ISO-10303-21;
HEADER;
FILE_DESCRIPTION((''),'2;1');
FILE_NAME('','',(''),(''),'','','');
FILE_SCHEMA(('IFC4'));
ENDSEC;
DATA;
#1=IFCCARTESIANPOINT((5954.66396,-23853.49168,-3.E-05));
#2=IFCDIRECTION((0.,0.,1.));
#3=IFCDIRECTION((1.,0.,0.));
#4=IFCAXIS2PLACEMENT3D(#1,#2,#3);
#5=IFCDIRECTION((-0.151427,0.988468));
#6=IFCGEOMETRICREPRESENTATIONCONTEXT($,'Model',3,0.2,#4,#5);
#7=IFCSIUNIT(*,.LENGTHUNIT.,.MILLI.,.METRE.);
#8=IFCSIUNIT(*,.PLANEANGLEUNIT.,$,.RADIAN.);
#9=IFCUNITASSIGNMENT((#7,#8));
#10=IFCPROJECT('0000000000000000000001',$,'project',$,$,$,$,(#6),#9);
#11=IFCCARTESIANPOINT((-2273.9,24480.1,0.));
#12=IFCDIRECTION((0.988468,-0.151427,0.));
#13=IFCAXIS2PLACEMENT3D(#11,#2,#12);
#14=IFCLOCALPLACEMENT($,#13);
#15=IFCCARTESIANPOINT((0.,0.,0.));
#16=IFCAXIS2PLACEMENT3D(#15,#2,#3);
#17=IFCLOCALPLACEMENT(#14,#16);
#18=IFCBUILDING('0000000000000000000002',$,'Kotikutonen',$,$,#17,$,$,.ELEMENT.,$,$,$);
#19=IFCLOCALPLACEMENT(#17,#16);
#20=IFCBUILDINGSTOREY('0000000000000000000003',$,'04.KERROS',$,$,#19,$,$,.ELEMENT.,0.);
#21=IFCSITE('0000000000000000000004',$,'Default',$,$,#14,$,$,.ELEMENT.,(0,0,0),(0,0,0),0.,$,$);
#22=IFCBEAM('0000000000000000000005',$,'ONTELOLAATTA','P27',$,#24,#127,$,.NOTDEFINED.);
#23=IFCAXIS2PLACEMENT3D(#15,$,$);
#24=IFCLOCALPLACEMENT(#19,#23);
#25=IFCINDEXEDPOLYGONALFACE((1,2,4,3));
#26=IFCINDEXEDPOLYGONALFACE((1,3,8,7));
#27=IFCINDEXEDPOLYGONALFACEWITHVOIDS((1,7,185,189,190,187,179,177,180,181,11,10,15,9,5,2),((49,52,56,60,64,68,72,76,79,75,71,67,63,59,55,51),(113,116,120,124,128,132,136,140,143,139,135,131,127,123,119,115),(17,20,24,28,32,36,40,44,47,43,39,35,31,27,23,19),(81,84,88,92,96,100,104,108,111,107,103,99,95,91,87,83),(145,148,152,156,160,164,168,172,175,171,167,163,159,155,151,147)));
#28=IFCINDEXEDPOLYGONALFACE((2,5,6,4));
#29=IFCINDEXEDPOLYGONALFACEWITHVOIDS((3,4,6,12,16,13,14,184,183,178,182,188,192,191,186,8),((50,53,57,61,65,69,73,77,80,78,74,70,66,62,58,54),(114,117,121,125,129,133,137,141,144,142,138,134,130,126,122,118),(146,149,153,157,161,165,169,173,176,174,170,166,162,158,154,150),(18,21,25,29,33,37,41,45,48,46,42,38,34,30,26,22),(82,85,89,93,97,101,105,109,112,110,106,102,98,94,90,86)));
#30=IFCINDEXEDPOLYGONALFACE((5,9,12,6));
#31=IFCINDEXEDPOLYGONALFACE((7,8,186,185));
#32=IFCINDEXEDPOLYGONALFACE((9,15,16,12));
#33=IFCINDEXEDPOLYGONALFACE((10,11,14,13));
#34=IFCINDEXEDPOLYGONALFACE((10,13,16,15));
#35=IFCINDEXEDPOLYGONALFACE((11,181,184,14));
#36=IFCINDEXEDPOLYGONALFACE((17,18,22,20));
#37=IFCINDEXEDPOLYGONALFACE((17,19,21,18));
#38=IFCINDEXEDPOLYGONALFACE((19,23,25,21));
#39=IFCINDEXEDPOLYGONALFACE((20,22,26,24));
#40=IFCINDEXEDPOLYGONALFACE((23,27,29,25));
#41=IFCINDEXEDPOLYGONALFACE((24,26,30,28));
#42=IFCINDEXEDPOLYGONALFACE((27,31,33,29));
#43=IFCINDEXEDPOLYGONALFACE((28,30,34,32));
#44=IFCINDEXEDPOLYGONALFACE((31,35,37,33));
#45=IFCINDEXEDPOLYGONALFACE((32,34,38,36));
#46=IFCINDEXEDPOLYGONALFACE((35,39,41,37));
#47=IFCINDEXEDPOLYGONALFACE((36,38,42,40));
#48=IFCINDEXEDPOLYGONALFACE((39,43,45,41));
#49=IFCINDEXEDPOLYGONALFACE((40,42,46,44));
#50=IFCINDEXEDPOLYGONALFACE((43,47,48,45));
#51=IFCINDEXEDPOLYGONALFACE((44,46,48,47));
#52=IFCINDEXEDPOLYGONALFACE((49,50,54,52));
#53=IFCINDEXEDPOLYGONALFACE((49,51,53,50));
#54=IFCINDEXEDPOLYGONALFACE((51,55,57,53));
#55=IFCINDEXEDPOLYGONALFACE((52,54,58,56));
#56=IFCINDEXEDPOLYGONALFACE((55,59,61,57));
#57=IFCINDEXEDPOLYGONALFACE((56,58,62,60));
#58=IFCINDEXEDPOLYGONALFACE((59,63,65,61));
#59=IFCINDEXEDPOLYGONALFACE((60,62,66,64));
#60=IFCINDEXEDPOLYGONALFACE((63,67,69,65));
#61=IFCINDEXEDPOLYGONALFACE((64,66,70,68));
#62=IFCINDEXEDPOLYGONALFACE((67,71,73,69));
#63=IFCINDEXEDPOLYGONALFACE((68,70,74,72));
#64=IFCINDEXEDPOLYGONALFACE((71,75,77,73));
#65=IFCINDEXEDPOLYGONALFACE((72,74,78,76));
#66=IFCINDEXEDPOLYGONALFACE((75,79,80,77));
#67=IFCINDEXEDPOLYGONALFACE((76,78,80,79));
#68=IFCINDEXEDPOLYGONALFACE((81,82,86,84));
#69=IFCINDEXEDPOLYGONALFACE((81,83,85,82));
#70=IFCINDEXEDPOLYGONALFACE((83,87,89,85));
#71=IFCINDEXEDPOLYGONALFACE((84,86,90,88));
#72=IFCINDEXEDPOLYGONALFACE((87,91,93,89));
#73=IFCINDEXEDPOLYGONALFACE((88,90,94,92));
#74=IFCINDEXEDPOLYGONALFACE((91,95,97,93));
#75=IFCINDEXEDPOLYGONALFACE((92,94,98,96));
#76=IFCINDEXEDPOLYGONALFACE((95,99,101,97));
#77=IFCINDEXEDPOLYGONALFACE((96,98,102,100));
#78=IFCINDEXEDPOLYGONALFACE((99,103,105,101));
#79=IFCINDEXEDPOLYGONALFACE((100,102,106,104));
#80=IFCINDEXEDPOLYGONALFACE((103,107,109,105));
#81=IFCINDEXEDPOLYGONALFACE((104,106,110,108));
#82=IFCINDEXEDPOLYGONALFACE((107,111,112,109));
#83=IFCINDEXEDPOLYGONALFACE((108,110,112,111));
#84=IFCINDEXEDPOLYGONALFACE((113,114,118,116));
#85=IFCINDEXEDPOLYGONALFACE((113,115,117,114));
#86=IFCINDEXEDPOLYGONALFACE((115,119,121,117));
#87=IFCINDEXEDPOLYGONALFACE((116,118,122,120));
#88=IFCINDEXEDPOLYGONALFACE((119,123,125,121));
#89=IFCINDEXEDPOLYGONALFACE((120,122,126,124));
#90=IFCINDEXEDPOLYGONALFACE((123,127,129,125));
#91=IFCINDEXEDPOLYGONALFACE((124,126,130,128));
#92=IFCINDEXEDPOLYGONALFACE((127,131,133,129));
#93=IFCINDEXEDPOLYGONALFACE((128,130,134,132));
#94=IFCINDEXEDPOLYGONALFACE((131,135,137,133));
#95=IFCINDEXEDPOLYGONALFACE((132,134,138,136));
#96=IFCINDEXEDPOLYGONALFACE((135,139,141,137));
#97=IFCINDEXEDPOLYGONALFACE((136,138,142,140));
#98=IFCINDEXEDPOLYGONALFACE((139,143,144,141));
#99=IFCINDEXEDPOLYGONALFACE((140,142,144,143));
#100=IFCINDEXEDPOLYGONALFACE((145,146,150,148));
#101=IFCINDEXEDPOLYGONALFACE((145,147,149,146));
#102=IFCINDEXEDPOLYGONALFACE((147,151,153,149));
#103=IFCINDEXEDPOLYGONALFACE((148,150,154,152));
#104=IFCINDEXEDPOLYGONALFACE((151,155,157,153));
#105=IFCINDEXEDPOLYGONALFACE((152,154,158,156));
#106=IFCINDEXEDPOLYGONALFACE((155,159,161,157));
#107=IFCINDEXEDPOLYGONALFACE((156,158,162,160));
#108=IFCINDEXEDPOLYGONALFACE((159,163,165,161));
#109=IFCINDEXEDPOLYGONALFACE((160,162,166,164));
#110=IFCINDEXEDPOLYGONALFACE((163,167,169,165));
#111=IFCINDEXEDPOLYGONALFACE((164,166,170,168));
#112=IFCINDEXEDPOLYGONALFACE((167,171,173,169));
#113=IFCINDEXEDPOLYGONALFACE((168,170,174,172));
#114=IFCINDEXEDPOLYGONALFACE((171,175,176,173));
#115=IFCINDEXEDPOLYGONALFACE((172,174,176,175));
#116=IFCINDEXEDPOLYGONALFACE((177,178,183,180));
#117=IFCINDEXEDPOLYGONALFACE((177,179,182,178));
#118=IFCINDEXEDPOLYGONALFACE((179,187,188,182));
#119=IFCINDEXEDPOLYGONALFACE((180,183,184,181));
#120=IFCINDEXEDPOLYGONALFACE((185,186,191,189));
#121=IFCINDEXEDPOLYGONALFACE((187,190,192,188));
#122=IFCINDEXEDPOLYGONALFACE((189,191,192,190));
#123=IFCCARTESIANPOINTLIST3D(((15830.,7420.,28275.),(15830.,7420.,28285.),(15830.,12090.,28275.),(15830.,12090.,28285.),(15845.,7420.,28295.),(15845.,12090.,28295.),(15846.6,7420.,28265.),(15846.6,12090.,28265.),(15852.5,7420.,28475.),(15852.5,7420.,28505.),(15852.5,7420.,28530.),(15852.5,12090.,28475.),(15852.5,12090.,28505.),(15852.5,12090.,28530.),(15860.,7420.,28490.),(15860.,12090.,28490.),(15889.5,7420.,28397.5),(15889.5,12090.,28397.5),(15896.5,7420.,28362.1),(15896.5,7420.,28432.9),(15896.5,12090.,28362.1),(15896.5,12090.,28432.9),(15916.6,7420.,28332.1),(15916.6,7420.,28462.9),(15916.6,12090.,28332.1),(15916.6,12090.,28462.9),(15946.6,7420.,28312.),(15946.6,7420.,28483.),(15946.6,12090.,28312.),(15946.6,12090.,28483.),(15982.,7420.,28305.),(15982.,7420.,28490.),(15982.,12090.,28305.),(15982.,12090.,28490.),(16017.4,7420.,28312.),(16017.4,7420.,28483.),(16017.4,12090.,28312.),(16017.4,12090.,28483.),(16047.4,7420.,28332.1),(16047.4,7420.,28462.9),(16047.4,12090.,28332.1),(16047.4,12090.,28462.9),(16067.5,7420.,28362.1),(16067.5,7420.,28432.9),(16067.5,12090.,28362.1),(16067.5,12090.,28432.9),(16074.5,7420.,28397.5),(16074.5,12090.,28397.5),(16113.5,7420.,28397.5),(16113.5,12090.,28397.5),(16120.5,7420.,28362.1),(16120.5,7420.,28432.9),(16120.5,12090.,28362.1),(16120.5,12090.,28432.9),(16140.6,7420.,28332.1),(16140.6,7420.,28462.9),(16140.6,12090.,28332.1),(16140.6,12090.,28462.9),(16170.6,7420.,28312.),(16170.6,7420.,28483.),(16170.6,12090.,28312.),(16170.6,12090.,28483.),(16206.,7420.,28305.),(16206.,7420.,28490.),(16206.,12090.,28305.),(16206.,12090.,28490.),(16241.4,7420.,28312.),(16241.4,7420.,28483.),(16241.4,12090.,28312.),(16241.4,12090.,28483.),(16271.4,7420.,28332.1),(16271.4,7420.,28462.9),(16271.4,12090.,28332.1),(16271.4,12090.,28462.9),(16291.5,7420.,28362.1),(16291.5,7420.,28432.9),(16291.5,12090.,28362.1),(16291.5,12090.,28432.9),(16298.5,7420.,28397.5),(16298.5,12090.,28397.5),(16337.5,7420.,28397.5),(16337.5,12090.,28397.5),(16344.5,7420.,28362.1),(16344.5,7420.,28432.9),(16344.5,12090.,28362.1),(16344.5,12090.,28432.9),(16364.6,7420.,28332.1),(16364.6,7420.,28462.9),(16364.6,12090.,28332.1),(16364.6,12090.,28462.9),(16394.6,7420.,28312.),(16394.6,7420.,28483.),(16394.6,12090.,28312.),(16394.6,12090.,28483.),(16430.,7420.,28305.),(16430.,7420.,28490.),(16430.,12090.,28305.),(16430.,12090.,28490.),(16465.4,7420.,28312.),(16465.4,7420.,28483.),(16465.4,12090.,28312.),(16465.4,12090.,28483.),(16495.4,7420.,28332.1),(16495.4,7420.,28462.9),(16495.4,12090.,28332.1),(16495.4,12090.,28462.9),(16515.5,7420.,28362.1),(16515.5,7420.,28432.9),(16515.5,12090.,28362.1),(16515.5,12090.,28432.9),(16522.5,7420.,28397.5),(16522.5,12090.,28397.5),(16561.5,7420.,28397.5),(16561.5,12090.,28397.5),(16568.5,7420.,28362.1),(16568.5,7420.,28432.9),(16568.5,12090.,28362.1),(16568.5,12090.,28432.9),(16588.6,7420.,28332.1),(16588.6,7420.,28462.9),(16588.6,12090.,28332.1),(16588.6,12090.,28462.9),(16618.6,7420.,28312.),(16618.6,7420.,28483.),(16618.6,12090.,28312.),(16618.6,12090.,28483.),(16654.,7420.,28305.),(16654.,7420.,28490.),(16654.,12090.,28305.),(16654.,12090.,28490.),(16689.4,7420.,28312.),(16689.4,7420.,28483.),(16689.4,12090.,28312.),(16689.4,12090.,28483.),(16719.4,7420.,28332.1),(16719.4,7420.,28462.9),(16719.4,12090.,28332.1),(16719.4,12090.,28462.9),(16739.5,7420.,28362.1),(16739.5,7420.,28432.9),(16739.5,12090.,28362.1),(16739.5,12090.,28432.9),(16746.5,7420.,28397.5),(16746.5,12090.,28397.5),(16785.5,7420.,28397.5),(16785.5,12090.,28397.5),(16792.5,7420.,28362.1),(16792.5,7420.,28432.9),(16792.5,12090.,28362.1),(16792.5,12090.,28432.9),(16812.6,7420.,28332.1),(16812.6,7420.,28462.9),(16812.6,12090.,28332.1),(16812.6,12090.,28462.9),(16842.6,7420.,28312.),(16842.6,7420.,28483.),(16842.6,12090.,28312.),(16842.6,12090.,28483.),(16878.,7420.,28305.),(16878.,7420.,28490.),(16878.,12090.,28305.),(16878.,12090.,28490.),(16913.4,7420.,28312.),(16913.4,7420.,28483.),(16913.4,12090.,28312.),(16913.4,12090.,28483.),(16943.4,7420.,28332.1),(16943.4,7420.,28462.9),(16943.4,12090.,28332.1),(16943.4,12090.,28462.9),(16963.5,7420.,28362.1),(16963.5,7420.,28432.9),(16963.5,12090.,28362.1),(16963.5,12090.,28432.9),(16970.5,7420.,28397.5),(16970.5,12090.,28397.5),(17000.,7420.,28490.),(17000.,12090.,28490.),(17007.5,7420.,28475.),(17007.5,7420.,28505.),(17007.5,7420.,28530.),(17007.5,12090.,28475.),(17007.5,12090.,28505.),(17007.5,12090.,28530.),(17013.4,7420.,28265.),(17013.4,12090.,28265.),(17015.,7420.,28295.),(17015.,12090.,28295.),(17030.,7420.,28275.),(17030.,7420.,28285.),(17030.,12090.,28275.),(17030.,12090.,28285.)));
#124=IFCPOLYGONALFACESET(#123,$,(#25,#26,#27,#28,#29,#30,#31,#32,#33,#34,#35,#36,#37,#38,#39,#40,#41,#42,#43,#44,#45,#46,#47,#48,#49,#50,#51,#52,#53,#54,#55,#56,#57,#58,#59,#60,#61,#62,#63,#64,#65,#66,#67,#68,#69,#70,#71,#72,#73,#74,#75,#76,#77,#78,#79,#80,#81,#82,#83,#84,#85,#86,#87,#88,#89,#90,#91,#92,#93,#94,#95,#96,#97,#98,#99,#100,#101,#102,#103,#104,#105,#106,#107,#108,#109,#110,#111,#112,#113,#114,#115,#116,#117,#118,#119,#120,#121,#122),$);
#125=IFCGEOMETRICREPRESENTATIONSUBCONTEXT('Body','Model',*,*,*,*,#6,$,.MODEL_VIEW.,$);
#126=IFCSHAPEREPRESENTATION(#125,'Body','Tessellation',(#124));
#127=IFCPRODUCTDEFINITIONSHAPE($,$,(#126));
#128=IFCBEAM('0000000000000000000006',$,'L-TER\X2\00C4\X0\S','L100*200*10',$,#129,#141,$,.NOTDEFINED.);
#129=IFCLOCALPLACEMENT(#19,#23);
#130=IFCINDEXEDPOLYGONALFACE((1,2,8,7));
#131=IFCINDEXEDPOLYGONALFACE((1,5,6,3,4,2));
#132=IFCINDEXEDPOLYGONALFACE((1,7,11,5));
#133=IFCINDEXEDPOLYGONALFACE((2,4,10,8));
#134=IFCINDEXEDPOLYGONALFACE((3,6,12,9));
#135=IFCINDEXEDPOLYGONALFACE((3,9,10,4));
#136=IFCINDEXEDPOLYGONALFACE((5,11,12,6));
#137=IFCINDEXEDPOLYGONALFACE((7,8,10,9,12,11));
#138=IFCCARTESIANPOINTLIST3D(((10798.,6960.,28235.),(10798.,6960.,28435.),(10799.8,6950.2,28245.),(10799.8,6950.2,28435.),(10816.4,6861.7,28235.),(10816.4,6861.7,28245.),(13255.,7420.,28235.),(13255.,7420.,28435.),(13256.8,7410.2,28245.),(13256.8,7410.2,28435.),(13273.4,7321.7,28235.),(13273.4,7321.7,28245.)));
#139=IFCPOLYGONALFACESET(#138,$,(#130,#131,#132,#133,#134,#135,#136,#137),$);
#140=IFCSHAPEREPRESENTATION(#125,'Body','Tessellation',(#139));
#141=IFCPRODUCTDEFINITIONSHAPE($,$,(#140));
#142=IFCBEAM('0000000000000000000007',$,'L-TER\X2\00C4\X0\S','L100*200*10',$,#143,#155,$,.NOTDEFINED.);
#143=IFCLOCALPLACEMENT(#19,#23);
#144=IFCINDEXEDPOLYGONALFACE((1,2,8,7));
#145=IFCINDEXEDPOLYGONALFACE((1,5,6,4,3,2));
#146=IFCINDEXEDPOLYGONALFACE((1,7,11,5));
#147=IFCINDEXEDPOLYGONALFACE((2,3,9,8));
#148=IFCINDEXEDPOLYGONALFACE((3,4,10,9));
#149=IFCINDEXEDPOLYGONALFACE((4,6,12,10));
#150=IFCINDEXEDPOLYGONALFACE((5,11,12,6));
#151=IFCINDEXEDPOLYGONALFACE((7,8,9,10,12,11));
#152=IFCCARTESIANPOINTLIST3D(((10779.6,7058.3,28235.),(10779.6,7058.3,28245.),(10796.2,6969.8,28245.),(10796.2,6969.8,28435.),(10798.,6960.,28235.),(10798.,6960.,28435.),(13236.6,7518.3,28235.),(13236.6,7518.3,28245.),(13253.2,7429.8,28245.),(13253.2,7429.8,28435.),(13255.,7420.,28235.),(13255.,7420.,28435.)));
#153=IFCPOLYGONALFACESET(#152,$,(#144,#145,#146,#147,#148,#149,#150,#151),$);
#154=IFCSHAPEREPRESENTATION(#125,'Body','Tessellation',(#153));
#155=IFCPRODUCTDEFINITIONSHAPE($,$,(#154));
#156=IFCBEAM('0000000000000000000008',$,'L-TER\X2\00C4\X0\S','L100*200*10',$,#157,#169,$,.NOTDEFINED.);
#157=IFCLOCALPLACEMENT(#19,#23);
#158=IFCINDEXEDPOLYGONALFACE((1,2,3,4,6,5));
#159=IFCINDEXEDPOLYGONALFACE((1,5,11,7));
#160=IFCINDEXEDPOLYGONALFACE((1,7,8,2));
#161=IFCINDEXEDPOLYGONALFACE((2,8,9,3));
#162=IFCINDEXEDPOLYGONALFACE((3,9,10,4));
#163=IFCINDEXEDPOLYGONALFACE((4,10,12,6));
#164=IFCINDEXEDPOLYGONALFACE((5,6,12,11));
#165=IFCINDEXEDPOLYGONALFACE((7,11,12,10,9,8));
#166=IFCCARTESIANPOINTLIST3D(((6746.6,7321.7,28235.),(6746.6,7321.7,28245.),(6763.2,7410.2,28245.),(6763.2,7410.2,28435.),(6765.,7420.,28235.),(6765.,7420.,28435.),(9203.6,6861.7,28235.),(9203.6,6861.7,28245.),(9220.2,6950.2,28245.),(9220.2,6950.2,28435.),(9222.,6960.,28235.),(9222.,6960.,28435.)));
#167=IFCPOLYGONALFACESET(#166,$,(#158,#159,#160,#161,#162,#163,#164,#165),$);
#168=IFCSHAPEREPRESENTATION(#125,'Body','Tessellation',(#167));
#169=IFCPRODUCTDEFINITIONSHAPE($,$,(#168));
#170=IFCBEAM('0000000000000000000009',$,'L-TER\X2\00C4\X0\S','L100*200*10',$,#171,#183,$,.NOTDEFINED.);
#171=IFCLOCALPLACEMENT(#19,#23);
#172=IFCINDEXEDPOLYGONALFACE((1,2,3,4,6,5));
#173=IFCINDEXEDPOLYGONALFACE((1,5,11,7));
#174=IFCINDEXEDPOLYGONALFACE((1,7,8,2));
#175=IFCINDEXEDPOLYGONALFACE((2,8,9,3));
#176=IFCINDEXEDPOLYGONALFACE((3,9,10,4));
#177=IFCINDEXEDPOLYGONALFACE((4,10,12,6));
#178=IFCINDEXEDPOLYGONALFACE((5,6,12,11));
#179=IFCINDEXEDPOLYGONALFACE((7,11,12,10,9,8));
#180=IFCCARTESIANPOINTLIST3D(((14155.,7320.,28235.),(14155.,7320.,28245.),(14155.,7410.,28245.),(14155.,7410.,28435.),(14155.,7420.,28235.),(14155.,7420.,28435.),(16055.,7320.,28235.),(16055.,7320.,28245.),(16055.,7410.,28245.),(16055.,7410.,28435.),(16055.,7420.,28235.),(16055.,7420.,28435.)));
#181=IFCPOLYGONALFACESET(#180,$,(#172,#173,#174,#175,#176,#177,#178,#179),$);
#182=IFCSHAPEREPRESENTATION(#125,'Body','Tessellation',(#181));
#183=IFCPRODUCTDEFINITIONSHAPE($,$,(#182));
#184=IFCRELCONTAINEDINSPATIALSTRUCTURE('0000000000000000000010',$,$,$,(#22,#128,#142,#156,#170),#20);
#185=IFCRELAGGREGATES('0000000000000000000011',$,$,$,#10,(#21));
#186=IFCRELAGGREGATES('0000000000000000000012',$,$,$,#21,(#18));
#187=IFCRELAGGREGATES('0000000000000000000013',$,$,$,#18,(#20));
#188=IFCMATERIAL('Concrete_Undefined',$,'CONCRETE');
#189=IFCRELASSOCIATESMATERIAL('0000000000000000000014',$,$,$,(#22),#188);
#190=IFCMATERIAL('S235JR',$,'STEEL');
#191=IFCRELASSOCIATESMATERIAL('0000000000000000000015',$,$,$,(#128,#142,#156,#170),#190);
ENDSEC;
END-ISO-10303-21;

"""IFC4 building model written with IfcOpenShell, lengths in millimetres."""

from ifc_helpers import new_model, si_unit, direction, frame, origin_with_axes, place, context, subcontext, project, spatial, line, indexed_curve, outline, extrude, material, element, save


model = new_model("IFC4")

# Units and contexts
model_context = context("Model", 3, precision=0.2, world=frame((5954.66396, -23853.49168, -3e-05), z_axis=(0.0, 0.0, 1.0), x_axis=(1.0, 0.0, 0.0)), true_north=direction((-0.151427, 0.988468)))
body_context = subcontext(model_context, "Body", "Model", "MODEL_VIEW")
ifc_project = project(units=[si_unit("LENGTHUNIT", "METRE", prefix="MILLI"), si_unit("PLANEANGLEUNIT", "RADIAN")], contexts=[model_context])

# Site, building, storey
site_placement = place(None, frame((-2273.9, 24480.1, 0.0), z_axis=(0.0, 0.0, 1.0), x_axis=(0.988468, -0.151427, 0.0)))
site = spatial("IfcSite", under=ifc_project, at=site_placement, Name="Default", CompositionType="ELEMENT", RefLatitude=(0, 0, 0), RefLongitude=(0, 0, 0), RefElevation=0.0)
building_placement = place(site_placement, origin_with_axes())
building = spatial("IfcBuilding", under=site, at=building_placement, Name="Kotikutonen", CompositionType="ELEMENT")
storey_placement = place(building_placement, origin_with_axes())
storey = spatial("IfcBuildingStorey", under=building, at=storey_placement, Name="04.KERROS", CompositionType="ELEMENT", Elevation=0.0)

# Beams
ifc_material_1 = material(Name="Concrete_Undefined", Category="CONCRETE")
beam_1_placement = place(storey_placement, frame((16430.0, 12090.0, 28397.5), z_axis=(-1.0, 0.0, 0.0), x_axis=(0.0, -1.0, 0.0)))
element("IfcBeam", 1, at=beam_1_placement, inside=storey, material=ifc_material_1, Name="ONTELOLAATTA", Description="P27", PredefinedType="NOTDEFINED", context=body_context, shape_type="SolidModel", body=[
    extrude(outline(indexed_curve([(-600.0, -122.5), (-583.4, -132.5), (583.4, -132.5), (600.0, -122.5), (600.0, -112.5), (585.0, -102.5), (577.5, 77.5), (570.0, 92.5), (577.5, 107.5), (577.5, 132.5), (-577.5, 132.5), (-577.5, 107.5), (-570.0, 92.5), (-577.5, 77.5), (-585.0, -102.5), (-600.0, -112.5)], segments=[line(1, 2, 3, 4, 5, 6, 7, 8, 9, 10, 11, 12, 13, 14, 15, 16, 1)]), holes=[indexed_curve([(-448.0, -92.5), (-483.4, -85.5), (-513.4, -65.4), (-533.5, -35.4), (-540.5, 0.0), (-533.5, 35.4), (-513.4, 65.4), (-483.4, 85.5), (-448.0, 92.5), (-412.6, 85.5), (-382.6, 65.4), (-362.5, 35.4), (-355.5, 0.0), (-362.5, -35.4), (-382.6, -65.4), (-412.6, -85.5)], segments=[line(1, 2, 3, 4, 5, 6, 7, 8, 9, 10, 11, 12, 13, 14, 15, 16, 1)]), indexed_curve([(-224.0, -92.5), (-259.4, -85.5), (-289.4, -65.4), (-309.5, -35.4), (-316.5, 0.0), (-309.5, 35.4), (-289.4, 65.4), (-259.4, 85.5), (-224.0, 92.5), (-188.6, 85.5), (-158.6, 65.4), (-138.5, 35.4), (-131.5, 0.0), (-138.5, -35.4), (-158.6, -65.4), (-188.6, -85.5)], segments=[line(1, 2, 3, 4, 5, 6, 7, 8, 9, 10, 11, 12, 13, 14, 15, 16, 1)]), indexed_curve([(0.0, -92.5), (-35.4, -85.5), (-65.4, -65.4), (-85.5, -35.4), (-92.5, 0.0), (-85.5, 35.4), (-65.4, 65.4), (-35.4, 85.5), (0.0, 92.5), (35.4, 85.5), (65.4, 65.4), (85.5, 35.4), (92.5, 0.0), (85.5, -35.4), (65.4, -65.4), (35.4, -85.5)], segments=[line(1, 2, 3, 4, 5, 6, 7, 8, 9, 10, 11, 12, 13, 14, 15, 16, 1)]), indexed_curve([(224.0, -92.5), (188.6, -85.5), (158.6, -65.4), (138.5, -35.4), (131.5, 0.0), (138.5, 35.4), (158.6, 65.4), (188.6, 85.5), (224.0, 92.5), (259.4, 85.5), (289.4, 65.4), (309.5, 35.4), (316.5, 0.0), (309.5, -35.4), (289.4, -65.4), (259.4, -85.5)], segments=[line(1, 2, 3, 4, 5, 6, 7, 8, 9, 10, 11, 12, 13, 14, 15, 16, 1)]), indexed_curve([(448.0, -92.5), (412.6, -85.5), (382.6, -65.4), (362.5, -35.4), (355.5, 0.0), (362.5, 35.4), (382.6, 65.4), (412.6, 85.5), (448.0, 92.5), (483.4, 85.5), (513.4, 65.4), (533.5, 35.4), (540.5, 0.0), (533.5, -35.4), (513.4, -65.4), (483.4, -85.5)], segments=[line(1, 2, 3, 4, 5, 6, 7, 8, 9, 10, 11, 12, 13, 14, 15, 16, 1)])]), frame((0.0, 0.0, 0.0), z_axis=(-1.0, 0.0, 0.0), x_axis=(0.0, 0.0, 1.0)), (0.0, 0.0, -1.0), 4670.0),
])
ifc_material_2 = material(Name="S235JR", Category="STEEL")
for number, where, z_axis, x_axis, name in (
    (2, (13264.2, 7370.9, 28335.0), (0.0, 0.0, 1.0), (-0.982922, -0.184023, 0.0), "L-TERÄS"),
    (3, (10788.8, 7009.1, 28335.0), (0.0, 0.0, 1.0), (0.982922, 0.184023, 0.0), "L-TERÄS"),
    (4, (9212.8, 6910.9, 28335.0), (0.0, 0.0, 1.0), (-0.982922, 0.184023, 0.0), "L-TERÄS"),
):
    element("IfcBeam", number, at=place(storey_placement, frame(where, z_axis=z_axis, x_axis=x_axis)), inside=storey, material=ifc_material_2, Name=name, Description="L100*200*10", PredefinedType="NOTDEFINED", context=body_context, shape_type="SolidModel", body=[
        extrude(outline(indexed_curve([(-100.0, -50.0), (100.0, -50.0), (100.0, -40.0), (-90.0, -40.0), (-90.0, 50.0), (-100.0, 50.0)], segments=[line(1, 2, 3, 4, 5, 6, 1)])), frame((0.0, 0.0, 0.0), z_axis=(-1.0, 0.0, 0.0), x_axis=(0.0, 0.0, 1.0)), (0.0, 0.0, -1.0), 2499.7),
    ])
for number, where, z_axis, x_axis, name in (
    (5, (16055.0, 7370.0, 28335.0), (0.0, 0.0, 1.0), (-1.0, 0.0, 0.0), "L-TERÄS"),
):
    element("IfcBeam", number, at=place(storey_placement, frame(where, z_axis=z_axis, x_axis=x_axis)), inside=storey, material=ifc_material_2, Name=name, Description="L100*200*10", PredefinedType="NOTDEFINED", context=body_context, shape_type="SolidModel", body=[
        extrude(outline(indexed_curve([(-100.0, -50.0), (100.0, -50.0), (100.0, -40.0), (-90.0, -40.0), (-90.0, 50.0), (-100.0, 50.0)], segments=[line(1, 2, 3, 4, 5, 6, 1)])), frame((0.0, 0.0, 0.0), z_axis=(-1.0, 0.0, 0.0), x_axis=(0.0, 0.0, 1.0)), (0.0, 0.0, -1.0), 1900.0),
    ])

save(model, "model.ifc")
